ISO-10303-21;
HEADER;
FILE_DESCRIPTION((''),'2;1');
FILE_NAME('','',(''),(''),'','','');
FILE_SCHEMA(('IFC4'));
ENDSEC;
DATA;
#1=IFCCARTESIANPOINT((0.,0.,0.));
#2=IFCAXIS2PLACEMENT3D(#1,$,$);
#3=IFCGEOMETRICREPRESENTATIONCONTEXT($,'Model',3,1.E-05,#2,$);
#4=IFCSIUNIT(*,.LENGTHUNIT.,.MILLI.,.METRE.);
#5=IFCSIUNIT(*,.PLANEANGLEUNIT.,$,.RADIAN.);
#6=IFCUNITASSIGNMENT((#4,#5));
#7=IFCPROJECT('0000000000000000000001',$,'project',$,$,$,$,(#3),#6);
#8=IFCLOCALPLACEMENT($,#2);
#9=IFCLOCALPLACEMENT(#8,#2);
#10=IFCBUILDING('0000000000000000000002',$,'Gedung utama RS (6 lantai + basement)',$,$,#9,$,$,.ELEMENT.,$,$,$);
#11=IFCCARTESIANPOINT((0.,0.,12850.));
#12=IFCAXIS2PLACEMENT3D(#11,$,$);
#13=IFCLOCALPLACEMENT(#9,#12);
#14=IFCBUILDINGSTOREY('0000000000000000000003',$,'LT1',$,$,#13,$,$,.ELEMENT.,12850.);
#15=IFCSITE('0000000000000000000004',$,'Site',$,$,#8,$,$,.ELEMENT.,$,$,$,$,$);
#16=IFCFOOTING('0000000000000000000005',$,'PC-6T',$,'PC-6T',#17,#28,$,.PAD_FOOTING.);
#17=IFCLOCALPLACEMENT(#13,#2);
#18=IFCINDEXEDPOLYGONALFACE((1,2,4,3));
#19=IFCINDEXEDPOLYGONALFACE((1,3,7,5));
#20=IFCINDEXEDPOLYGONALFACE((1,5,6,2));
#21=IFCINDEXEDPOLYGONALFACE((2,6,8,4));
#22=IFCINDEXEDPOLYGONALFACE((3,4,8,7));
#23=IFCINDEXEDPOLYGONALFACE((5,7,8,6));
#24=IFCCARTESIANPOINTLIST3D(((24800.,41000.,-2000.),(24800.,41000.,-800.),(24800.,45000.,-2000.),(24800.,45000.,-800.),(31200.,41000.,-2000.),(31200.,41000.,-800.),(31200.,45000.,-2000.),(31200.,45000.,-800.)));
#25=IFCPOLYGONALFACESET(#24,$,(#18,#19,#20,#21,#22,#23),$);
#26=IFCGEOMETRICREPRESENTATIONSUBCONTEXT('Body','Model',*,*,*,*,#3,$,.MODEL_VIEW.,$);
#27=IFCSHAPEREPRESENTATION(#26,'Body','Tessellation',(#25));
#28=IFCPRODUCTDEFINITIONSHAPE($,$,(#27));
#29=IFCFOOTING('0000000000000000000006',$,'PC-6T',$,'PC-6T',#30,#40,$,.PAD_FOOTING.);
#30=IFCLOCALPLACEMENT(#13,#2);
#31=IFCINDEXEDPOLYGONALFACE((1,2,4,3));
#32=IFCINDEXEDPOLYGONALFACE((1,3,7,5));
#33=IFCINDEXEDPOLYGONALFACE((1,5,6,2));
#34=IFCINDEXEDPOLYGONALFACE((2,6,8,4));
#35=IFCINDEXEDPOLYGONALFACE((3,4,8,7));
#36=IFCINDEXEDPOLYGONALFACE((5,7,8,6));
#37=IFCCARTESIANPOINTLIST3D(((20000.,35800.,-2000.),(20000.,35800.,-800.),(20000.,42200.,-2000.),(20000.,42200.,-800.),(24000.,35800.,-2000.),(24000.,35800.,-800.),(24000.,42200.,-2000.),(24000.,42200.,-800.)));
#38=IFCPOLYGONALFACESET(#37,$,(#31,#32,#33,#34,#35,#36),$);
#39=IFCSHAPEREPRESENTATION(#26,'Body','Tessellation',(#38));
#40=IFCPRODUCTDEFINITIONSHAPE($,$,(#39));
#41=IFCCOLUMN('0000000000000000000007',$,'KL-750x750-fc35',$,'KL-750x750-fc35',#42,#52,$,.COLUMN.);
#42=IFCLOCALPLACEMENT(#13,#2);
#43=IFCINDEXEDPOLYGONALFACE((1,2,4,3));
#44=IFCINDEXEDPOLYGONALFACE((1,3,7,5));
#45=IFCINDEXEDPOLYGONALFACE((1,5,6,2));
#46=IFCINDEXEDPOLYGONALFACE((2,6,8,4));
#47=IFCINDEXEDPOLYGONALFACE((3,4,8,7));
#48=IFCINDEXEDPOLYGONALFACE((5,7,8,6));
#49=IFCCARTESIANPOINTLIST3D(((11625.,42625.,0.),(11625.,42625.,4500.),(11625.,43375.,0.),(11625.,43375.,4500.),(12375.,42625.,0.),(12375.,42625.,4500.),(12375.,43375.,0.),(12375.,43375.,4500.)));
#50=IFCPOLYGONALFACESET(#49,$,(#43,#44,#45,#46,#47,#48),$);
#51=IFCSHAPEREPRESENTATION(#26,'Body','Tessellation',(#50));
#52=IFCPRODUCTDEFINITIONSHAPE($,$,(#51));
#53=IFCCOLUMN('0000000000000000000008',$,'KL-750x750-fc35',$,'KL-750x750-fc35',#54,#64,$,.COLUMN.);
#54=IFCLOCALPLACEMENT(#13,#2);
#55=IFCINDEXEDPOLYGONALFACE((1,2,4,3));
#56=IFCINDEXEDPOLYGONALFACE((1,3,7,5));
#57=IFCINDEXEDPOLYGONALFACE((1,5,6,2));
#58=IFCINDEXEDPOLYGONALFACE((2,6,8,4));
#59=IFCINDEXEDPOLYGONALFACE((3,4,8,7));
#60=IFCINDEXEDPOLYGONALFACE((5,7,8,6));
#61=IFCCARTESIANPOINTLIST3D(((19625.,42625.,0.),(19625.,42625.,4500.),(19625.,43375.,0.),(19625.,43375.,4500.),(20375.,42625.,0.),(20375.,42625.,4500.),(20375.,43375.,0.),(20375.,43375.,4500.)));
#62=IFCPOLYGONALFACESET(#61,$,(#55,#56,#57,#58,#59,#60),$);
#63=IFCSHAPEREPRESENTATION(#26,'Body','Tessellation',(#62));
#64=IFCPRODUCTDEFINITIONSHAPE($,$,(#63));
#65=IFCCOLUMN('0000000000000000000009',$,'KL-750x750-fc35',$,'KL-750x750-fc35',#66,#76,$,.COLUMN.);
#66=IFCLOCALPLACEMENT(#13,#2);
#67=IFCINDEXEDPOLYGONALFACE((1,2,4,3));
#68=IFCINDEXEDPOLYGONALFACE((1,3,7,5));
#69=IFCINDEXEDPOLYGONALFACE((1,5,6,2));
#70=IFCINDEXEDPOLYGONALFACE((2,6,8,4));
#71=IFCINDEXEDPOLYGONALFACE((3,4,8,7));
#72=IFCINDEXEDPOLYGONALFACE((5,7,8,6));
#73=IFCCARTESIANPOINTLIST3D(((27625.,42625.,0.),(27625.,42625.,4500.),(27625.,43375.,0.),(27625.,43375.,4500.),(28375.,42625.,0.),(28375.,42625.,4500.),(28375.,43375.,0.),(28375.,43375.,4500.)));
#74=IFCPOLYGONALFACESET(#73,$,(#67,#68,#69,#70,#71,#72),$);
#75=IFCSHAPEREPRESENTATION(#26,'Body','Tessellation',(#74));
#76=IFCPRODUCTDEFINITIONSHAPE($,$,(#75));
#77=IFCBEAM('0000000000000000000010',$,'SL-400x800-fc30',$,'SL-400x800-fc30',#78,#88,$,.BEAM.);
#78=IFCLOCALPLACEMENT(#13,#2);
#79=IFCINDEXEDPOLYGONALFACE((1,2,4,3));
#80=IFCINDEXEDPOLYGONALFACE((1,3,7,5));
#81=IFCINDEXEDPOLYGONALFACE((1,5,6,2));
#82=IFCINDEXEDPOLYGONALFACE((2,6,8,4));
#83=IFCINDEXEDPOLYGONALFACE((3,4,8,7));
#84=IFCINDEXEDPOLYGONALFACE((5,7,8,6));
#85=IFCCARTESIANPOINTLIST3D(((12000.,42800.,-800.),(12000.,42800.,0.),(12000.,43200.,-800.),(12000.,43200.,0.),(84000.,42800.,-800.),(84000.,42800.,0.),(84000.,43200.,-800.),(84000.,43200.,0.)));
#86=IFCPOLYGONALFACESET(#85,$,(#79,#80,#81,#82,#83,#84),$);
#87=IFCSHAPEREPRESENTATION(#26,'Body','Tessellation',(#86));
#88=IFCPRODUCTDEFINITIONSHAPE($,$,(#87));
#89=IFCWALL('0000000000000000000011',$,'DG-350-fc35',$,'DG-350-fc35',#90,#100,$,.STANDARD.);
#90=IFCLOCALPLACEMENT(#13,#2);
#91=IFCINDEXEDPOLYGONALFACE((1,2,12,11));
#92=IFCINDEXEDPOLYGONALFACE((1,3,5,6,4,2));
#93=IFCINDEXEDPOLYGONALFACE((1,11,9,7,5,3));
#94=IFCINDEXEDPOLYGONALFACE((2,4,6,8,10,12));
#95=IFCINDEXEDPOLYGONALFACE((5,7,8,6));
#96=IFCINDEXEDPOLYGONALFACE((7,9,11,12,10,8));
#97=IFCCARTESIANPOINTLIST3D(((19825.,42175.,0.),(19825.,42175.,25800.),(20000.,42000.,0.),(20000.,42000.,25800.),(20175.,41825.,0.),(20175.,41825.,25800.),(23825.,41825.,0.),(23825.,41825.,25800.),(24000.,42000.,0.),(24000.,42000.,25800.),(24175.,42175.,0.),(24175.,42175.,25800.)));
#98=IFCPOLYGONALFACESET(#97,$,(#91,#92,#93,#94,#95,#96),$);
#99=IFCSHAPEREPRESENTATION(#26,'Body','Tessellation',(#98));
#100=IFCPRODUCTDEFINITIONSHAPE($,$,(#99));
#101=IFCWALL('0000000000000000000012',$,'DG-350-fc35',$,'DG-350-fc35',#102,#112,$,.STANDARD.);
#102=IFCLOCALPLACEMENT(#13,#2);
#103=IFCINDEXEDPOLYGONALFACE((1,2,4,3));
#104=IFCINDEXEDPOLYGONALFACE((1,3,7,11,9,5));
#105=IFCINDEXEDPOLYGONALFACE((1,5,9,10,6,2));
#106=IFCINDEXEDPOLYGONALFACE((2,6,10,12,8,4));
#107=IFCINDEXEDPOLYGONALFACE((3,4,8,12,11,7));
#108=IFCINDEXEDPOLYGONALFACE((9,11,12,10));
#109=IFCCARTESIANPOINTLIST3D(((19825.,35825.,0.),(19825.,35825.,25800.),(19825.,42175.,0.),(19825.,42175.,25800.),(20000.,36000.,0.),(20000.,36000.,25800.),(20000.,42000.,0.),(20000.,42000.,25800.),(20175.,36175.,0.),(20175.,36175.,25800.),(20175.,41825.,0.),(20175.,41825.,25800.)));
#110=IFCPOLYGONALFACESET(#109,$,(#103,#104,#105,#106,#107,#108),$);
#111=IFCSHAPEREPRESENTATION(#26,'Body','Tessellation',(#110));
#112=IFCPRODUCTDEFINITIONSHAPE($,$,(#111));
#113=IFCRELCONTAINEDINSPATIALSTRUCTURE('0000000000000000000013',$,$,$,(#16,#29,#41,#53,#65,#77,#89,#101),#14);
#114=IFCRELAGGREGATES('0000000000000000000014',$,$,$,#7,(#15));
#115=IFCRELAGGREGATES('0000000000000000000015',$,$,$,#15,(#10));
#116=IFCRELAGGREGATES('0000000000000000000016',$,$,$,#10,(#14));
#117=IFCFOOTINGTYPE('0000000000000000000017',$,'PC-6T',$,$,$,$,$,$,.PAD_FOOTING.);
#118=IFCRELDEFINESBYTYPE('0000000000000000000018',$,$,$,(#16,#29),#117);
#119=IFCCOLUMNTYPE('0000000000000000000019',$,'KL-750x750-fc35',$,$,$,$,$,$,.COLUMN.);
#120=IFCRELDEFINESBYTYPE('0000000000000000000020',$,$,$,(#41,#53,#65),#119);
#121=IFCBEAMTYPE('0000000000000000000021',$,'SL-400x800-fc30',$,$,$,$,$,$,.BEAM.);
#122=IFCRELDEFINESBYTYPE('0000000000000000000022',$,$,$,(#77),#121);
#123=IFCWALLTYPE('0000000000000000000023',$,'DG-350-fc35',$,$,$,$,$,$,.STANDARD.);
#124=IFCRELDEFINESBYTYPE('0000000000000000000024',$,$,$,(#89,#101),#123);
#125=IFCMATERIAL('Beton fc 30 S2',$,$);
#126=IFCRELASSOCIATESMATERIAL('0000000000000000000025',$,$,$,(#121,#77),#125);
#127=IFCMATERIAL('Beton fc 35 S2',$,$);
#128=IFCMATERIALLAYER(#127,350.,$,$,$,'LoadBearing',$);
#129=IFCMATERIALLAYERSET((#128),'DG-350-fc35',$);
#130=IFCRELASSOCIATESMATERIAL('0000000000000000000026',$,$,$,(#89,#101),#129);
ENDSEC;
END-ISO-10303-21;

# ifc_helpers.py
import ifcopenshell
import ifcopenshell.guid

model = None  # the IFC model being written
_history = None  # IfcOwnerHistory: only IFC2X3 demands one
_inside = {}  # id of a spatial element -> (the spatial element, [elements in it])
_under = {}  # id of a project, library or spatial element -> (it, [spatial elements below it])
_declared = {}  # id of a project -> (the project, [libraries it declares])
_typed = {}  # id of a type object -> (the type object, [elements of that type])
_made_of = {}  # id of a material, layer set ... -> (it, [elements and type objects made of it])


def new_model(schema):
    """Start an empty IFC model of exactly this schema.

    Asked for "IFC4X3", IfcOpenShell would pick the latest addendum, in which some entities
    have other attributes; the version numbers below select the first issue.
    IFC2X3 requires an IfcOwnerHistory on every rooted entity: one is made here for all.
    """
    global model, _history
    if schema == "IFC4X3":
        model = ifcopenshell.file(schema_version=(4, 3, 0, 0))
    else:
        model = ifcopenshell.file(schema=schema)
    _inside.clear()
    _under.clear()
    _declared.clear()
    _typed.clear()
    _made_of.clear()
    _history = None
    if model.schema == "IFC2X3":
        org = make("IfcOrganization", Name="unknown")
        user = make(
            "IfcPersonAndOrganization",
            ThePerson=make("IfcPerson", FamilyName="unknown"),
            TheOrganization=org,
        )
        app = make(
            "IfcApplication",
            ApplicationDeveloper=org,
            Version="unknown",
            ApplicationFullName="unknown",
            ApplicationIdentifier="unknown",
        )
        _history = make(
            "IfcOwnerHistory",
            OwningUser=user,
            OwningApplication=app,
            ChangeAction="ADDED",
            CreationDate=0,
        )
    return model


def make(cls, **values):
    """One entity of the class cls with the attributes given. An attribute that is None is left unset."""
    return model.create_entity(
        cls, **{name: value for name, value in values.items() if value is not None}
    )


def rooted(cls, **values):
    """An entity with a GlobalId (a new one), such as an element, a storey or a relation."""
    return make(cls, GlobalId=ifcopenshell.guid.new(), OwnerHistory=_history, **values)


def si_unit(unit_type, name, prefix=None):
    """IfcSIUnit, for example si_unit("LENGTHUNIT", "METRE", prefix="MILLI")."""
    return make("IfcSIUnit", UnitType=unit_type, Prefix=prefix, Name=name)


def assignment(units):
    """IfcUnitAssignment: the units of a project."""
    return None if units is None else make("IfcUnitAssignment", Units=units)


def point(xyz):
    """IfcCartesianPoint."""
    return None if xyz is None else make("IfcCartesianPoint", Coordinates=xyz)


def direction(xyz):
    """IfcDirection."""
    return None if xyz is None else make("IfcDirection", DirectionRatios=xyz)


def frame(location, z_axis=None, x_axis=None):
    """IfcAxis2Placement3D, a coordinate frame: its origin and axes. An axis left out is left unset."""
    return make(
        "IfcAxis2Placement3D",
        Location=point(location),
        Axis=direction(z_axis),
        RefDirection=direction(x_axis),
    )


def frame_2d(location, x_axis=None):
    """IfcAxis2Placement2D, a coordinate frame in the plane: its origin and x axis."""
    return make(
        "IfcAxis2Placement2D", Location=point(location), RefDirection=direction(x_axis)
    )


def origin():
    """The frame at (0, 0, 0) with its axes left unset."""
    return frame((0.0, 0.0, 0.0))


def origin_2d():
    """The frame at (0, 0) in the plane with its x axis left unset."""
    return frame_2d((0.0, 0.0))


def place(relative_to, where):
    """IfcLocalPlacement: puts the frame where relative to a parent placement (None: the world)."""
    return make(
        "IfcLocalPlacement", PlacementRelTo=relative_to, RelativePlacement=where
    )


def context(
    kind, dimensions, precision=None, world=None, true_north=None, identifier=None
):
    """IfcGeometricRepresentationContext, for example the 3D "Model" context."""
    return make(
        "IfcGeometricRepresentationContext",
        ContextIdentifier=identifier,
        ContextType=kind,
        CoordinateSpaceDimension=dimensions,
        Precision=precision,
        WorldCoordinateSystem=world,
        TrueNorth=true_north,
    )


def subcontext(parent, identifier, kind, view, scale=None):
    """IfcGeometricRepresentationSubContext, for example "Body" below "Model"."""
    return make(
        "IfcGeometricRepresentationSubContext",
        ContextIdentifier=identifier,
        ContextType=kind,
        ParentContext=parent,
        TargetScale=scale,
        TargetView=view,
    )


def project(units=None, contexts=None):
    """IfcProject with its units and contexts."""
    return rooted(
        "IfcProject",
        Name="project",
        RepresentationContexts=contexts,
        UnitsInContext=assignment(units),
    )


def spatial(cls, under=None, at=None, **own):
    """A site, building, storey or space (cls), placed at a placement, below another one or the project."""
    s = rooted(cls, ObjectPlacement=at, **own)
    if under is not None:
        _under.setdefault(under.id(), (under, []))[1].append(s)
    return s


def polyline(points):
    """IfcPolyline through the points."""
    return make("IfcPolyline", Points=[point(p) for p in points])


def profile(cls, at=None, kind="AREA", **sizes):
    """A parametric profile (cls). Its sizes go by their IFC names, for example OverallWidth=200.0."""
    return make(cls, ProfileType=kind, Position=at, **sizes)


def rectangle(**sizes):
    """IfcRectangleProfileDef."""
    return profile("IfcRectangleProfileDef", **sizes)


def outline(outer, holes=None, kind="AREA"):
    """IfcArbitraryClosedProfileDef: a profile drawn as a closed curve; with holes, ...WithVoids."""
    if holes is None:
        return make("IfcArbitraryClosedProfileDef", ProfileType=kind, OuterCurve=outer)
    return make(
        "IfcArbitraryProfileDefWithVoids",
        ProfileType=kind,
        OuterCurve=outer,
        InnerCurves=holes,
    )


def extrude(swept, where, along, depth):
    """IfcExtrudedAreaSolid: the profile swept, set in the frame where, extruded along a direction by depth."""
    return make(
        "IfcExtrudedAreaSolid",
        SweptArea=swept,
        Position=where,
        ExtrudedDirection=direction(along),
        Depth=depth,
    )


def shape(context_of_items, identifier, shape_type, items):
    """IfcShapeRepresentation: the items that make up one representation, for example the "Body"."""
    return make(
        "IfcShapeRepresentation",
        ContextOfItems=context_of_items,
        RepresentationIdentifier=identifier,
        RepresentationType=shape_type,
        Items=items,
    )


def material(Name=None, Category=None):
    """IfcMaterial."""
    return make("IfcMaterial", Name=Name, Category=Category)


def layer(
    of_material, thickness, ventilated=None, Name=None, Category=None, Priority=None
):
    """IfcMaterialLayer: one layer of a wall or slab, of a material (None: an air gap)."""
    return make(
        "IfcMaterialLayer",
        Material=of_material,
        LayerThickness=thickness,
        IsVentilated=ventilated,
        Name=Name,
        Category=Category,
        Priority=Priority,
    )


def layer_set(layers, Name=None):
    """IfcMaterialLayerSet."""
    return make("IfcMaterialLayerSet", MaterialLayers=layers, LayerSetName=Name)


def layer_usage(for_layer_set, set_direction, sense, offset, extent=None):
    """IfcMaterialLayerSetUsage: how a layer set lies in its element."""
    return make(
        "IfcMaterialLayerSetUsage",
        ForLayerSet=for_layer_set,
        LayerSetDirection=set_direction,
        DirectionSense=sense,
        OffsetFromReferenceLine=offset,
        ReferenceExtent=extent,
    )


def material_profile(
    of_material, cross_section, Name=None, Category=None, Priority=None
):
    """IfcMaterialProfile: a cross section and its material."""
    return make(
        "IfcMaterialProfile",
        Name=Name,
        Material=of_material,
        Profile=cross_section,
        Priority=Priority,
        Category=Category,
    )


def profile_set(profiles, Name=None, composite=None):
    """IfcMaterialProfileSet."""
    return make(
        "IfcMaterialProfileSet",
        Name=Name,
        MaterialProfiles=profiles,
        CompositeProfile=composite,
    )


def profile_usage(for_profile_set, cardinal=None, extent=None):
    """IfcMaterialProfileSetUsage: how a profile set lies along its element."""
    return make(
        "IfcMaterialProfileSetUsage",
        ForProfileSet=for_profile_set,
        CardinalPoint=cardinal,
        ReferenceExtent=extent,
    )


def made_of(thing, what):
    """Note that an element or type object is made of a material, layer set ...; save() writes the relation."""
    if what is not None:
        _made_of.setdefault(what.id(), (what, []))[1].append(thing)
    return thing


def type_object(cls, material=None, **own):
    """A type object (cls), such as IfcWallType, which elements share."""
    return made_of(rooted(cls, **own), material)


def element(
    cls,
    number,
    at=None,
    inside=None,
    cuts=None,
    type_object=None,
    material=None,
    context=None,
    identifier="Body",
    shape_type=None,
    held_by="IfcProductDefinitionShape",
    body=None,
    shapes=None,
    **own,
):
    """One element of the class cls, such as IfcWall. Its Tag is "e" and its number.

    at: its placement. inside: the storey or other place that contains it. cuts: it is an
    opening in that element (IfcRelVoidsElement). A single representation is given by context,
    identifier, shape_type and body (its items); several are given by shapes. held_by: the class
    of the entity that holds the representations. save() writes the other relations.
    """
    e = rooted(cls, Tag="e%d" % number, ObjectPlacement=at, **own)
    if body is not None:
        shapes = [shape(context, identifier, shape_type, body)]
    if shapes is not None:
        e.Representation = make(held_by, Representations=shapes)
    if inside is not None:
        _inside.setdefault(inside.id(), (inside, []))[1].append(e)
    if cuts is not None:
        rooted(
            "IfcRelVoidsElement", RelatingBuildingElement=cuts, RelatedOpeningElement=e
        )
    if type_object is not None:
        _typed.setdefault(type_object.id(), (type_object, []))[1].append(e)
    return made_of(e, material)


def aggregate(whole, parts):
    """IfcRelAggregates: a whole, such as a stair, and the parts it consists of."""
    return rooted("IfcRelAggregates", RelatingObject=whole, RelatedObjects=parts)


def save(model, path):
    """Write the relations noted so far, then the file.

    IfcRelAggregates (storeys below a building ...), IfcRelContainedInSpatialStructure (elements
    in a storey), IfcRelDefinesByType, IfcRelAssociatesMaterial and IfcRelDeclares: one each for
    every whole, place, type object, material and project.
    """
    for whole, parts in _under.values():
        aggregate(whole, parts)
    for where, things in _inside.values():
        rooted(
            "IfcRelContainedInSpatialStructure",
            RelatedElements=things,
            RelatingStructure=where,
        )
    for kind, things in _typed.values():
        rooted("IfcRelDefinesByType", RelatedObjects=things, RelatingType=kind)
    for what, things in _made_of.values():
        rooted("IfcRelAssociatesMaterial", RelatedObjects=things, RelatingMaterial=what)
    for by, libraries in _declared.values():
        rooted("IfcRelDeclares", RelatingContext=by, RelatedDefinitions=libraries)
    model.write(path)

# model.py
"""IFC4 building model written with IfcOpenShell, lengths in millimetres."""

from ifc_helpers import new_model, si_unit, frame, origin, origin_2d, place, context, subcontext, project, spatial, polyline, rectangle, outline, extrude, material, layer, layer_set, layer_usage, material_profile, profile_set, profile_usage, type_object, element, save


model = new_model("IFC4")

# Units and contexts
model_context = context("Model", 3, precision=1e-05, world=origin())
body_context = subcontext(model_context, "Body", "Model", "MODEL_VIEW")
ifc_project = project(units=[si_unit("LENGTHUNIT", "METRE", prefix="MILLI"), si_unit("PLANEANGLEUNIT", "RADIAN")], contexts=[model_context])

# Site, building, storey
site_placement = place(None, origin())
site = spatial("IfcSite", under=ifc_project, at=site_placement, Name="Site", CompositionType="ELEMENT")
building_placement = place(site_placement, origin())
building = spatial("IfcBuilding", under=site, at=building_placement, Name="Gedung utama RS (6 lantai + basement)", CompositionType="ELEMENT")
storey_placement = place(building_placement, frame((0.0, 0.0, 12850.0)))
storey = spatial("IfcBuildingStorey", under=building, at=storey_placement, Name="LT1", CompositionType="ELEMENT", Elevation=12850.0)

# Footings
ifc_material_profile_1 = material_profile(None, rectangle(XDim=6400.0, YDim=4000.0, at=origin_2d()), Name="PC-6T")
ifc_profile_set_1 = profile_set([ifc_material_profile_1], Name="PC-6T")
ifc_profile_usage_1 = profile_usage(ifc_profile_set_1, cardinal=5)
footing_type_1 = type_object("IfcFootingType", Name="PC-6T", PredefinedType="PAD_FOOTING", material=ifc_profile_set_1)
for number, where, z_axis, x_axis, name in (
    (1, (28000.0, 43000.0, -2000.0), (0.0, 0.0, 1.0), (1.0, 0.0, 0.0), "PC-6T"),
    (2, (22000.0, 39000.0, -2000.0), (0.0, 0.0, 1.0), (0.0, 1.0, 0.0), "PC-6T"),
):
    element("IfcFooting", number, at=place(storey_placement, frame(where, z_axis=z_axis, x_axis=x_axis)), inside=storey, type_object=footing_type_1, material=ifc_profile_usage_1, Name=name, ObjectType="PC-6T", PredefinedType="PAD_FOOTING", context=body_context, shape_type="SweptSolid", body=[
        extrude(rectangle(XDim=6400.0, YDim=4000.0, at=origin_2d()), origin(), (0.0, 0.0, 1.0), 1200.0),
    ])

# Columns
ifc_material_profile_2 = material_profile(None, rectangle(XDim=750.0, YDim=750.0, at=origin_2d()), Name="KL-750x750-fc35")
ifc_profile_set_2 = profile_set([ifc_material_profile_2], Name="KL-750x750-fc35")
ifc_profile_usage_2 = profile_usage(ifc_profile_set_2, cardinal=5)
column_type = type_object("IfcColumnType", Name="KL-750x750-fc35", PredefinedType="COLUMN", material=ifc_profile_set_2)
for number, where, z_axis, x_axis, name in (
    (3, (12000.0, 43000.0, 0.0), (0.0, 0.0, 1.0), (1.0, 0.0, 0.0), "KL-750x750-fc35"),
    (4, (20000.0, 43000.0, 0.0), (0.0, 0.0, 1.0), (1.0, 0.0, 0.0), "KL-750x750-fc35"),
    (5, (28000.0, 43000.0, 0.0), (0.0, 0.0, 1.0), (1.0, 0.0, 0.0), "KL-750x750-fc35"),
):
    element("IfcColumn", number, at=place(storey_placement, frame(where, z_axis=z_axis, x_axis=x_axis)), inside=storey, type_object=column_type, material=ifc_profile_usage_2, Name=name, ObjectType="KL-750x750-fc35", PredefinedType="COLUMN", context=body_context, shape_type="SweptSolid", body=[
        extrude(rectangle(XDim=750.0, YDim=750.0, at=origin_2d()), origin(), (0.0, 0.0, 1.0), 4500.0),
    ])

# Beam
ifc_material_1 = material(Name="Beton fc 30 S2")
ifc_material_profile_3 = material_profile(ifc_material_1, rectangle(XDim=400.0, YDim=800.0, at=origin_2d()), Name="SL-400x800-fc30")
ifc_profile_set_3 = profile_set([ifc_material_profile_3], Name="SL-400x800-fc30")
ifc_profile_usage_3 = profile_usage(ifc_profile_set_3, cardinal=8)
beam_type = type_object("IfcBeamType", Name="SL-400x800-fc30", PredefinedType="BEAM", material=ifc_profile_set_3)
beam_placement = place(storey_placement, frame((12000.0, 43000.0, -400.0)))
element("IfcBeam", 6, at=beam_placement, inside=storey, type_object=beam_type, material=ifc_profile_usage_3, Name="SL-400x800-fc30", ObjectType="SL-400x800-fc30", PredefinedType="BEAM", context=body_context, shape_type="SweptSolid", body=[
    extrude(rectangle(XDim=400.0, YDim=800.0, at=origin_2d()), frame((0.0, 0.0, 0.0), z_axis=(1.0, 0.0, 0.0), x_axis=(0.0, 1.0, 0.0)), (0.0, 0.0, 1.0), 72000.0),
])

# Walls
ifc_material_2 = material(Name="Beton fc 35 S2")
ifc_layer = layer(ifc_material_2, 350.0, Category="LoadBearing")
ifc_layer_set = layer_set([ifc_layer], Name="DG-350-fc35")
ifc_layer_usage = layer_usage(ifc_layer_set, "AXIS2", "NEGATIVE", 175.0)
wall_type = type_object("IfcWallType", Name="DG-350-fc35", PredefinedType="STANDARD")
wall_1_placement = place(storey_placement, frame((24000.0, 42000.0, 0.0), z_axis=(0.0, 0.0, 1.0), x_axis=(-1.0, 0.0, 0.0)))
element("IfcWall", 7, at=wall_1_placement, inside=storey, type_object=wall_type, material=ifc_layer_usage, Name="DG-350-fc35", ObjectType="DG-350-fc35", PredefinedType="STANDARD", context=body_context, shape_type="SweptSolid", body=[
    extrude(outline(polyline([(-175.0, -175.0), (0.0, 0.0), (175.0, 175.0), (3825.0, 175.0), (4000.0, 0.0), (4175.0, -175.0), (-175.0, -175.0)])), origin(), (0.0, 0.0, 1.0), 25800.0),
])
wall_2_placement = place(storey_placement, frame((20000.0, 42000.0, 0.0), z_axis=(0.0, 0.0, 1.0), x_axis=(0.0, -1.0, 0.0)))
element("IfcWall", 8, at=wall_2_placement, inside=storey, type_object=wall_type, material=ifc_layer_usage, Name="DG-350-fc35", ObjectType="DG-350-fc35", PredefinedType="STANDARD", context=body_context, shape_type="SweptSolid", body=[
    extrude(outline(polyline([(-175.0, -175.0), (0.0, 0.0), (175.0, 175.0), (5825.0, 175.0), (6000.0, 0.0), (6175.0, -175.0), (-175.0, -175.0)])), origin(), (0.0, 0.0, 1.0), 25800.0),
])

save(model, "model.ifc")
